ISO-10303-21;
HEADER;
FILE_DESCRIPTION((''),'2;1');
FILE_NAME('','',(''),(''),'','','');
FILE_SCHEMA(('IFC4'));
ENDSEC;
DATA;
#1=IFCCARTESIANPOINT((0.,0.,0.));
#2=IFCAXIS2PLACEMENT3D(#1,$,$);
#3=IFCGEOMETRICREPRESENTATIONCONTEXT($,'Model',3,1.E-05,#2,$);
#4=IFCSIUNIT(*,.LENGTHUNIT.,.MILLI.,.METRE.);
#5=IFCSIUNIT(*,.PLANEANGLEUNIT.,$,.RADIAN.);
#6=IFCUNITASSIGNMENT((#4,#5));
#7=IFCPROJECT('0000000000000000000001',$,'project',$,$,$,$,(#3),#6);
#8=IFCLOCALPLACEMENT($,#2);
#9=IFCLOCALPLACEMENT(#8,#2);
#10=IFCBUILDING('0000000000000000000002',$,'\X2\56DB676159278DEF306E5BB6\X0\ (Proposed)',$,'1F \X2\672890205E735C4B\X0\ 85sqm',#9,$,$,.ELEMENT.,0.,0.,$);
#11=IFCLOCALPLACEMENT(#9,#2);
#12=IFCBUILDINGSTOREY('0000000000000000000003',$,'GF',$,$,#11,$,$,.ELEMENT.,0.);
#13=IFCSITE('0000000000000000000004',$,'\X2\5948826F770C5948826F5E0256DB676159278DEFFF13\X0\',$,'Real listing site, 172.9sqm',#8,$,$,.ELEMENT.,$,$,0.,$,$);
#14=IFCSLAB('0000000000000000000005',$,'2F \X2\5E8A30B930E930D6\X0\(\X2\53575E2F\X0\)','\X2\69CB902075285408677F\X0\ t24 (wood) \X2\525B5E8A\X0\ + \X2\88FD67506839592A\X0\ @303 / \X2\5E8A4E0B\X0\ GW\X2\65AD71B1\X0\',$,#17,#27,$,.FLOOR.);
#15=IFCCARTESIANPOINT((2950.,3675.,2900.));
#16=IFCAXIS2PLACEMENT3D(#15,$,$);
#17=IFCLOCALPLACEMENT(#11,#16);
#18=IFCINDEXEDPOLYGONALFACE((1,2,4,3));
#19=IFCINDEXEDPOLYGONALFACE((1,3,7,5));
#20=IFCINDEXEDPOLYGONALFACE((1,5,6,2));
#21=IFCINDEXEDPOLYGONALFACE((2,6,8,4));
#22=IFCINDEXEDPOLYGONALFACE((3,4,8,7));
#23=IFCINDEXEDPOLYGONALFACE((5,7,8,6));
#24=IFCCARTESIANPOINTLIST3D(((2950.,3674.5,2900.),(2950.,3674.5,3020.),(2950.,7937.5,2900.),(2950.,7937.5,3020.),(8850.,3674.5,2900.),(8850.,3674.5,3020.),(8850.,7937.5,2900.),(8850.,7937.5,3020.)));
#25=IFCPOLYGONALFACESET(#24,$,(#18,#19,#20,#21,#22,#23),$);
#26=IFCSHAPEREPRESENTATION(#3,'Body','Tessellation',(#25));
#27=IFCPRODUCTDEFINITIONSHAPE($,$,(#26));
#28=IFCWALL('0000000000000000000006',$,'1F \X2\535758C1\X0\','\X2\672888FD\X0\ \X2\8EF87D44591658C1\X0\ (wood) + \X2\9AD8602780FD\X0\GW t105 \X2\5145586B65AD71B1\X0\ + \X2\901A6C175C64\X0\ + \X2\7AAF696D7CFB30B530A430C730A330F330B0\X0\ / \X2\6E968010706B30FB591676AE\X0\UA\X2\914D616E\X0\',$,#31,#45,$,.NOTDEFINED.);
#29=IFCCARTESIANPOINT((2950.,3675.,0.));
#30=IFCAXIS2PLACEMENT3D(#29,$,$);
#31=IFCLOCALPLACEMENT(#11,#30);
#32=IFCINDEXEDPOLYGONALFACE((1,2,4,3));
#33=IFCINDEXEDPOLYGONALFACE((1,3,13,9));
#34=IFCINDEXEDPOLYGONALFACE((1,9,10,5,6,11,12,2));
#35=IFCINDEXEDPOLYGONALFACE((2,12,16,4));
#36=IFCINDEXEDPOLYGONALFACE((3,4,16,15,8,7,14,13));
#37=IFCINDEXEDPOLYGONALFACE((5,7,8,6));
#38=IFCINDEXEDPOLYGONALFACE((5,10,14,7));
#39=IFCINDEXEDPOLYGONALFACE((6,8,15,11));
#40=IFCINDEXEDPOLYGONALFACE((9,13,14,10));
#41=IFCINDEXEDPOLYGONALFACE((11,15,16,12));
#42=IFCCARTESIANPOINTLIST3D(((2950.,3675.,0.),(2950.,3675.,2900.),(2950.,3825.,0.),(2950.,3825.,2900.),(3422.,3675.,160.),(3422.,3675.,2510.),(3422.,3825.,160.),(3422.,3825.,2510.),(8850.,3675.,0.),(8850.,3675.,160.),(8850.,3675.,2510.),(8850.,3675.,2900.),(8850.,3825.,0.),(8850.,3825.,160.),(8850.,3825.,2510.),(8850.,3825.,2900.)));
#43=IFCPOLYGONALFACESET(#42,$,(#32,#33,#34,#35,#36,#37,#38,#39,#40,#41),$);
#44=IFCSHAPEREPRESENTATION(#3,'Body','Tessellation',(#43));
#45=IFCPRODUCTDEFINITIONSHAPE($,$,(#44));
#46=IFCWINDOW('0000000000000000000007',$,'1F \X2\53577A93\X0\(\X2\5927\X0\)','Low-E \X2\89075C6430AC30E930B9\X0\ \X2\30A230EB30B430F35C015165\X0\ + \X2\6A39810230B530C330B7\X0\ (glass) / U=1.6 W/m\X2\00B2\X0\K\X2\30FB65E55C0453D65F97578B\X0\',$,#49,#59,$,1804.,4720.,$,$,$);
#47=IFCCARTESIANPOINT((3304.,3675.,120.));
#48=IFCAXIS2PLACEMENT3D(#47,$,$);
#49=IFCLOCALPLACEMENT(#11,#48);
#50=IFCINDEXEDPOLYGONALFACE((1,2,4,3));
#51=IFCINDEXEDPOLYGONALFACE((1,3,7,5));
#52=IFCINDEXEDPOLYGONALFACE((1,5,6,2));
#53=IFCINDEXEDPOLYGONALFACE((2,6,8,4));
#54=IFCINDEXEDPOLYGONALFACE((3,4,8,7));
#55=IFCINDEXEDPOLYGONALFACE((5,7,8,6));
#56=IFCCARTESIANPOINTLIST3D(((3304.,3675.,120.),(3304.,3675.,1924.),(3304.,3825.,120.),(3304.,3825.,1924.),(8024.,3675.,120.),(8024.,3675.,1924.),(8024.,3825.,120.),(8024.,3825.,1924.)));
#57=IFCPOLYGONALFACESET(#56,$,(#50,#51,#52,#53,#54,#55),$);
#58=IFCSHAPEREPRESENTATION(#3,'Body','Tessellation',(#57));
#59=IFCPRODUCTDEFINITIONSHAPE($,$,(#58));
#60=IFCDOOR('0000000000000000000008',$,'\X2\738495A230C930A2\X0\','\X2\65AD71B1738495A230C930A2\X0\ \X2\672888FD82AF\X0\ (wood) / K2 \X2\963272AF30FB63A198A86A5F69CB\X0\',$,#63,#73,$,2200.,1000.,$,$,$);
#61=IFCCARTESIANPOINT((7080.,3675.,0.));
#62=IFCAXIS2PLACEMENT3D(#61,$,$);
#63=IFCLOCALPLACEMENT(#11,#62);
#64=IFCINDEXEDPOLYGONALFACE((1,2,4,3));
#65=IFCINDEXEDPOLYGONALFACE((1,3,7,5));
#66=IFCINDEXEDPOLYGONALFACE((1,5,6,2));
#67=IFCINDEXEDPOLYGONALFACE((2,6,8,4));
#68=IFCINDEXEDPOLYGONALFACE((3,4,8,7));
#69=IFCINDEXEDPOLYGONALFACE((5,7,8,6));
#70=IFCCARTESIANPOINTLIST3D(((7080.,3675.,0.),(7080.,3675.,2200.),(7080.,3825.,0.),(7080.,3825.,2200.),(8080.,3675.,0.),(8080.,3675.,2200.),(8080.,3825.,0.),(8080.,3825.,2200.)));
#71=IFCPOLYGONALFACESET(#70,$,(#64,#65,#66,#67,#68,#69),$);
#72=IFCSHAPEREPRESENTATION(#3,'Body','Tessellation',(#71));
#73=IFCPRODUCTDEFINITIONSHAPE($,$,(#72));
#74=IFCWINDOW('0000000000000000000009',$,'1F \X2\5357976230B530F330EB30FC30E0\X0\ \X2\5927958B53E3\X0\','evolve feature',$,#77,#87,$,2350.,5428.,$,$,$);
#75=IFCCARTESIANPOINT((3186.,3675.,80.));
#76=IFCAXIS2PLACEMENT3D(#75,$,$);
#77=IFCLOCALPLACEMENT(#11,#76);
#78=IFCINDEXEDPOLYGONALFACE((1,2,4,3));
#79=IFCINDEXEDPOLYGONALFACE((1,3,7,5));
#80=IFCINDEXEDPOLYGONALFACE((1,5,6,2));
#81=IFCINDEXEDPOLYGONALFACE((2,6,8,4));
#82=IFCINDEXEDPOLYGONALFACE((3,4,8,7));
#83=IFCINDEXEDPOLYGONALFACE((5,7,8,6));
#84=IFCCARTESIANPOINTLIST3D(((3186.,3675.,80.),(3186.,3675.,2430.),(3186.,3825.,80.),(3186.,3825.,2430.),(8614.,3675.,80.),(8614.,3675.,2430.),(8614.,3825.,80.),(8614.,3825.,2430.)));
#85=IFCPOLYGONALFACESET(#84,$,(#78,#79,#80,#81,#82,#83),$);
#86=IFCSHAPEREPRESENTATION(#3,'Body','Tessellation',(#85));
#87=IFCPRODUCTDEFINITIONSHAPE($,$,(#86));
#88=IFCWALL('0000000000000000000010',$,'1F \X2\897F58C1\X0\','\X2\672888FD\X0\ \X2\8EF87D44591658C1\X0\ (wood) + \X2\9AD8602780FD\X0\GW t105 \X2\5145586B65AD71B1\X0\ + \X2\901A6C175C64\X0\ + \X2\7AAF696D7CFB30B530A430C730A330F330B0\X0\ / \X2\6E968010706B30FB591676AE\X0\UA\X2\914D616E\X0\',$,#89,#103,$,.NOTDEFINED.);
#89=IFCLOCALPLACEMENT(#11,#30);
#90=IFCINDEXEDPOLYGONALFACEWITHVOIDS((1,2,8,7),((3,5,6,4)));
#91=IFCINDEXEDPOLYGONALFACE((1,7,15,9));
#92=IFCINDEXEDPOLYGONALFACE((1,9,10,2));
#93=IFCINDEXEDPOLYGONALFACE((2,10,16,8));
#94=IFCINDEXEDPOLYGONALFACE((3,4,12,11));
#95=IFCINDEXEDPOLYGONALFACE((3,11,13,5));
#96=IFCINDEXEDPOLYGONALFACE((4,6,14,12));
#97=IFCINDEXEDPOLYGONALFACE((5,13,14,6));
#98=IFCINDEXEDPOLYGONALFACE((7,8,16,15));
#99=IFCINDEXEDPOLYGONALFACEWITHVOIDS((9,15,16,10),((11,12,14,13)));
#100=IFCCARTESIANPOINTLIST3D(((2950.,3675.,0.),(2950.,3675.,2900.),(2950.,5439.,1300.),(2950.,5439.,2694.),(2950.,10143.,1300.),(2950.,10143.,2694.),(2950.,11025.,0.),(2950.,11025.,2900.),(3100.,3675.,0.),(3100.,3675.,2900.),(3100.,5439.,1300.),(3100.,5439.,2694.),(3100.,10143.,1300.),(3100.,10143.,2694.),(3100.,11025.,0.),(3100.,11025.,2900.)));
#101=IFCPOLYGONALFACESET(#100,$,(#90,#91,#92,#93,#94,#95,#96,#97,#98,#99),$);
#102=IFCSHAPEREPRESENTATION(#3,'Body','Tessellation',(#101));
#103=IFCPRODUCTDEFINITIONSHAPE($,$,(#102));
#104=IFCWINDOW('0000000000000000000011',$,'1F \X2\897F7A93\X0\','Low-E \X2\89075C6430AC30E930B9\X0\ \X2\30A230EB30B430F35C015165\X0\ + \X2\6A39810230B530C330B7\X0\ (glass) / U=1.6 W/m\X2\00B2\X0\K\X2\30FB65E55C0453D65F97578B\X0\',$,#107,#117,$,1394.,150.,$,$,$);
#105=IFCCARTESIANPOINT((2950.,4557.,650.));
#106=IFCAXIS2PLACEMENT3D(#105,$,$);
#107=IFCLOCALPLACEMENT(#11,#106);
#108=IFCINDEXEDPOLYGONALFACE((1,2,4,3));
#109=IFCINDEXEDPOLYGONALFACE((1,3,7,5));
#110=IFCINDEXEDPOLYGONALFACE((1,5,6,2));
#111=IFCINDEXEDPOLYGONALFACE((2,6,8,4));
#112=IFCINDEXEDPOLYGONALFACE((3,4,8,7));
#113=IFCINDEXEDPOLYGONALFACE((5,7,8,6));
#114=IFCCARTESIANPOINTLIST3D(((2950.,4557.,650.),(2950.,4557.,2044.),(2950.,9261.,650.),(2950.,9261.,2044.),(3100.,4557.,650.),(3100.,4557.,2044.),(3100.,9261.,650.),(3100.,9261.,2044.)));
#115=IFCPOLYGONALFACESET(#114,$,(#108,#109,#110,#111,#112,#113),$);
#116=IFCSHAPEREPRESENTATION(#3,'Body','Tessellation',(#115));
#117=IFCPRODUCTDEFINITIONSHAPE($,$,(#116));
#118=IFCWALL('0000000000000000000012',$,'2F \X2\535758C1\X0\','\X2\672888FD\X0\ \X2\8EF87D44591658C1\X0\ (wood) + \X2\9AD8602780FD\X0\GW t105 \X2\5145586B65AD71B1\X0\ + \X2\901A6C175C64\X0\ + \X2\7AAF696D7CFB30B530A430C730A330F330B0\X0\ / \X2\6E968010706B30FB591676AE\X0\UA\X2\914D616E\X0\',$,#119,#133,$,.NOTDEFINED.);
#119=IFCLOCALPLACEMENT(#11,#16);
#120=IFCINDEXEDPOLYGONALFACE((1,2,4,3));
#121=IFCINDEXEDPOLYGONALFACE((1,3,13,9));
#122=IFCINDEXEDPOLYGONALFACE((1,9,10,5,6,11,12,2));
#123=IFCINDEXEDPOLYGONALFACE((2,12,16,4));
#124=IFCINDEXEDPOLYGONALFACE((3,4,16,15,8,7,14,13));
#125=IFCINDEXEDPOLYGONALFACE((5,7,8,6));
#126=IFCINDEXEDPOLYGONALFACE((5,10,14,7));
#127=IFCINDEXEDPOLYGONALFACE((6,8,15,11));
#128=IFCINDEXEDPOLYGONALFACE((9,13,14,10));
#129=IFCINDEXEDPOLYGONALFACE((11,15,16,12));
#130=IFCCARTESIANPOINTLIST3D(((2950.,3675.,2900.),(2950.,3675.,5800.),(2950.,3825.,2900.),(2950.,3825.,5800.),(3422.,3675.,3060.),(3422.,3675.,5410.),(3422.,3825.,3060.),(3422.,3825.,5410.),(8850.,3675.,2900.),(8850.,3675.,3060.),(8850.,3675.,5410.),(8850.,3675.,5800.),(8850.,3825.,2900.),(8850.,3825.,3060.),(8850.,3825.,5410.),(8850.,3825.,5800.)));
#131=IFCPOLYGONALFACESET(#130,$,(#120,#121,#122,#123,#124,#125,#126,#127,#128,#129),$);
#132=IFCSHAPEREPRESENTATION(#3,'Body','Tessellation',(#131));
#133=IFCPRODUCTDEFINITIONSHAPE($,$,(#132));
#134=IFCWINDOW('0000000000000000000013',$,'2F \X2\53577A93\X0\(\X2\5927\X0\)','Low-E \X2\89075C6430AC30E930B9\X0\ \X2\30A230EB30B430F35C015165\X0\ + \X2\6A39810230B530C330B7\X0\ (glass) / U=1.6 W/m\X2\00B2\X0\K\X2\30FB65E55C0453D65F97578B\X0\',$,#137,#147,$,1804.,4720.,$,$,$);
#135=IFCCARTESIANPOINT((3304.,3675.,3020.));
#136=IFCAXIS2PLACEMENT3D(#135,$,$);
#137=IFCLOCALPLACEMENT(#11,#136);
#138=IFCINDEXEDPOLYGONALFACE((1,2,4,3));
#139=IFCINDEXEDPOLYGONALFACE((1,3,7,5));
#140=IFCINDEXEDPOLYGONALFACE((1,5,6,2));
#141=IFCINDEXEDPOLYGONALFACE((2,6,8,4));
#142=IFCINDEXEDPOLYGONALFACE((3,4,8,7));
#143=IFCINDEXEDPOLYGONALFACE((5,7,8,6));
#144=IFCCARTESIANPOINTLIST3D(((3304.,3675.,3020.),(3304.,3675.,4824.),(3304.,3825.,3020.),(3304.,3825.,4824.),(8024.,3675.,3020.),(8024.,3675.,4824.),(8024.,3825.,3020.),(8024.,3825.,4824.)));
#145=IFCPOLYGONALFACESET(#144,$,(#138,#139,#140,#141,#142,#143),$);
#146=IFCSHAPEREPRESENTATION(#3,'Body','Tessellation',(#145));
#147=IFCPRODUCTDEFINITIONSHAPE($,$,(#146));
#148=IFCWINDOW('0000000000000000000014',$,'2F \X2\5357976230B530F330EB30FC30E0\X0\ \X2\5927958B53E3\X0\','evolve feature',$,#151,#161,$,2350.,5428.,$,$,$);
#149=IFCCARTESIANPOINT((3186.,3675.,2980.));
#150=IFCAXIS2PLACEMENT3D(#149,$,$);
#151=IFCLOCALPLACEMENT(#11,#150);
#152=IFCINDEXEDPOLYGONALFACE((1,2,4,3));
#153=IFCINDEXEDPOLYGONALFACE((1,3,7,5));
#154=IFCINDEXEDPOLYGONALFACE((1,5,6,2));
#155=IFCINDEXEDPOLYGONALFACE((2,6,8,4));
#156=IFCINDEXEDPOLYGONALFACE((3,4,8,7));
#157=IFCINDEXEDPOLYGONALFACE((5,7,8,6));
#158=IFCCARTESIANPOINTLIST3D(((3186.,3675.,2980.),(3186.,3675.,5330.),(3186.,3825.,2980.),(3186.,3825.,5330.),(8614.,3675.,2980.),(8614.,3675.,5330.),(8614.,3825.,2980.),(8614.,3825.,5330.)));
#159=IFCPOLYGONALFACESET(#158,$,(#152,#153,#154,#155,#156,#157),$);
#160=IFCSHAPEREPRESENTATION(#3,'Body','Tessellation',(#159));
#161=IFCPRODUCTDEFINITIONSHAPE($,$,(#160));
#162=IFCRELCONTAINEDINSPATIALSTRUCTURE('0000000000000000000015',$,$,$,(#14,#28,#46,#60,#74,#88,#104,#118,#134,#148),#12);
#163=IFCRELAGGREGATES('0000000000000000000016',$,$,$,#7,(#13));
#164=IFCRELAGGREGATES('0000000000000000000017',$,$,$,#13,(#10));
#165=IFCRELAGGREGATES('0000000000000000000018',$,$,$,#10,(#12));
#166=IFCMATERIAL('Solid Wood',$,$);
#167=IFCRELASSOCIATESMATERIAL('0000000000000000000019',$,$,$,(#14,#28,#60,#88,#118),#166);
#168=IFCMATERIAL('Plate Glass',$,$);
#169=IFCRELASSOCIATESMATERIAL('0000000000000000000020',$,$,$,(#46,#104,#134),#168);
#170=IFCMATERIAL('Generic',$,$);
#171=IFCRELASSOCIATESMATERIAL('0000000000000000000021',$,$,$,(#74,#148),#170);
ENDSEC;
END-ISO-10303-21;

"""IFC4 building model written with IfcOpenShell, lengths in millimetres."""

from ifc_helpers import new_model, si_unit, frame, frame_2d, origin, place, context, project, spatial, rectangle, extrude, material, element, fill, save


model = new_model("IFC4")

# Units and contexts
model_context = context("Model", 3, precision=1e-05, world=origin())
ifc_project = project(units=[si_unit("LENGTHUNIT", "METRE", prefix="MILLI"), si_unit("PLANEANGLEUNIT", "RADIAN")], contexts=[model_context])

# Site, building, storey
site_placement = place(None, origin())
site = spatial("IfcSite", under=ifc_project, at=site_placement, Name="奈良県奈良市四条大路３", ObjectType="Real listing site, 172.9sqm", CompositionType="ELEMENT", RefElevation=0.0)
building_placement = place(site_placement, origin())
building = spatial("IfcBuilding", under=site, at=building_placement, Name="四条大路の家 (Proposed)", ObjectType="1F 木造平屋 85sqm", CompositionType="ELEMENT", ElevationOfRefHeight=0.0, ElevationOfTerrain=0.0)
storey_placement = place(building_placement, origin())
storey = spatial("IfcBuildingStorey", under=building, at=storey_placement, Name="GF", CompositionType="ELEMENT", Elevation=0.0)

# Slab
ifc_material_1 = material(Name="Solid Wood")
slab_1_placement = place(storey_placement, frame((2950.0, 3675.0, 2900.0)))
element("IfcSlab", 1, at=slab_1_placement, inside=storey, material=ifc_material_1, Name="2F 床スラブ(南帯)", Description="構造用合板 t24 (wood) 剛床 + 製材根太 @303 / 床下 GW断熱", PredefinedType="FLOOR", context=model_context, shape_type="SweptSolid", body=[
    extrude(rectangle(XDim=5900.0, YDim=4263.0, at=frame_2d((2950.0, 2131.0))), frame((2950.0, 3675.0, 2900.0)), (0.0, 0.0, 1.0), 120.0),
])
ifc_material_2 = material(Name="Generic")

# Wall, openings, windows, door
wall_1_placement = place(storey_placement, frame((2950.0, 3675.0, 0.0)))
wall_1 = element("IfcWall", 2, at=wall_1_placement, inside=storey, material=ifc_material_1, Name="1F 南壁", Description="木製 軸組外壁 (wood) + 高性能GW t105 充填断熱 + 通気層 + 窯業系サイディング / 準耐火・外皮UA配慮", PredefinedType="NOTDEFINED", context=model_context, shape_type="SweptSolid", body=[
    extrude(rectangle(XDim=5900.0, YDim=150.0, at=frame_2d((2950.0, 75.0))), frame((2950.0, 3675.0, 0.0)), (0.0, 0.0, 1.0), 2900.0),
])
opening_1_placement = place(storey_placement, frame((3304.0, 3675.0, 120.0)))
opening_1 = element("IfcOpeningElement", 3, at=opening_1_placement, cuts=wall_1, PredefinedType="NOTDEFINED", context=model_context, shape_type="SweptSolid", body=[
    extrude(rectangle(XDim=4720.0, YDim=150.0, at=frame_2d((2360.0, 75.0))), frame((3304.0, 3675.0, 120.0)), (0.0, 0.0, 1.0), 1804.0),
])
opening_2_placement = place(storey_placement, frame((7080.0, 3675.0, 0.0)))
opening_2 = element("IfcOpeningElement", 4, at=opening_2_placement, cuts=wall_1, PredefinedType="NOTDEFINED", context=model_context, shape_type="SweptSolid", body=[
    extrude(rectangle(XDim=1000.0, YDim=150.0, at=frame_2d((500.0, 75.0))), frame((7080.0, 3675.0, 0.0)), (0.0, 0.0, 1.0), 2200.0),
])
opening_3_placement = place(storey_placement, frame((3186.0, 3675.0, 80.0)))
opening_3 = element("IfcOpeningElement", 5, at=opening_3_placement, cuts=wall_1, PredefinedType="NOTDEFINED", context=model_context, shape_type="SweptSolid", body=[
    extrude(rectangle(XDim=5428.0, YDim=150.0, at=frame_2d((2714.0, 75.0))), frame((3186.0, 3675.0, 80.0)), (0.0, 0.0, 1.0), 2350.0),
])
ifc_material_3 = material(Name="Plate Glass")
window_1_placement = place(storey_placement, frame((3304.0, 3675.0, 120.0)))
window_1 = element("IfcWindow", 6, at=window_1_placement, inside=storey, material=ifc_material_3, Name="1F 南窓(大)", Description="Low-E 複層ガラス アルゴン封入 + 樹脂サッシ (glass) / U=1.6 W/m²K・日射取得型", OverallHeight=1804.0, OverallWidth=4720.0, context=model_context, shape_type="SweptSolid", body=[
    extrude(rectangle(XDim=4720.0, YDim=150.0, at=frame_2d((2360.0, 75.0))), frame((3304.0, 3675.0, 120.0)), (0.0, 0.0, 1.0), 1804.0),
])
fill(opening_1, window_1)
door_placement = place(storey_placement, frame((7080.0, 3675.0, 0.0)))
door = element("IfcDoor", 7, at=door_placement, inside=storey, material=ifc_material_1, Name="玄関ドア", Description="断熱玄関ドア 木製芯 (wood) / K2 防犯・採風機構", OverallHeight=2200.0, OverallWidth=1000.0, context=model_context, shape_type="SweptSolid", body=[
    extrude(rectangle(XDim=1000.0, YDim=150.0, at=frame_2d((500.0, 75.0))), frame((7080.0, 3675.0, 0.0)), (0.0, 0.0, 1.0), 2200.0),
])
fill(opening_2, door)
window_2_placement = place(storey_placement, frame((3186.0, 3675.0, 80.0)))
window_2 = element("IfcWindow", 8, at=window_2_placement, inside=storey, material=ifc_material_2, Name="1F 南面サンルーム 大開口", Description="evolve feature", OverallHeight=2350.0, OverallWidth=5428.0, context=model_context, shape_type="SweptSolid", body=[
    extrude(rectangle(XDim=5428.0, YDim=150.0, at=frame_2d((2714.0, 75.0))), frame((3186.0, 3675.0, 80.0)), (0.0, 0.0, 1.0), 2350.0),
])
fill(opening_3, window_2)

# Wall, opening, window
wall_2_placement = place(storey_placement, frame((2950.0, 3675.0, 0.0)))
wall_2 = element("IfcWall", 9, at=wall_2_placement, inside=storey, material=ifc_material_1, Name="1F 西壁", Description="木製 軸組外壁 (wood) + 高性能GW t105 充填断熱 + 通気層 + 窯業系サイディング / 準耐火・外皮UA配慮", PredefinedType="NOTDEFINED", context=model_context, shape_type="SweptSolid", body=[
    extrude(rectangle(XDim=150.0, YDim=7350.0, at=frame_2d((75.0, 3675.0))), frame((2950.0, 3675.0, 0.0)), (0.0, 0.0, 1.0), 2900.0),
])
opening_4_placement = place(storey_placement, frame((2950.0, 4557.0, 650.0)))
opening_4 = element("IfcOpeningElement", 10, at=opening_4_placement, cuts=wall_2, PredefinedType="NOTDEFINED", context=model_context, shape_type="SweptSolid", body=[
    extrude(rectangle(XDim=150.0, YDim=4704.0, at=frame_2d((75.0, 2352.0))), frame((2950.0, 4557.0, 650.0)), (0.0, 0.0, 1.0), 1394.0),
])
window_3_placement = place(storey_placement, frame((2950.0, 4557.0, 650.0)))
window_3 = element("IfcWindow", 11, at=window_3_placement, inside=storey, material=ifc_material_3, Name="1F 西窓", Description="Low-E 複層ガラス アルゴン封入 + 樹脂サッシ (glass) / U=1.6 W/m²K・日射取得型", OverallHeight=1394.0, OverallWidth=150.0, context=model_context, shape_type="SweptSolid", body=[
    extrude(rectangle(XDim=150.0, YDim=4704.0, at=frame_2d((75.0, 2352.0))), frame((2950.0, 4557.0, 650.0)), (0.0, 0.0, 1.0), 1394.0),
])
fill(opening_4, window_3)

# Wall, openings, windows
wall_3_placement = place(storey_placement, frame((2950.0, 3675.0, 2900.0)))
wall_3 = element("IfcWall", 12, at=wall_3_placement, inside=storey, material=ifc_material_1, Name="2F 南壁", Description="木製 軸組外壁 (wood) + 高性能GW t105 充填断熱 + 通気層 + 窯業系サイディング / 準耐火・外皮UA配慮", PredefinedType="NOTDEFINED", context=model_context, shape_type="SweptSolid", body=[
    extrude(rectangle(XDim=5900.0, YDim=150.0, at=frame_2d((2950.0, 75.0))), frame((2950.0, 3675.0, 2900.0)), (0.0, 0.0, 1.0), 2900.0),
])
opening_5_placement = place(storey_placement, frame((3304.0, 3675.0, 3020.0)))
opening_5 = element("IfcOpeningElement", 13, at=opening_5_placement, cuts=wall_3, PredefinedType="NOTDEFINED", context=model_context, shape_type="SweptSolid", body=[
    extrude(rectangle(XDim=4720.0, YDim=150.0, at=frame_2d((2360.0, 75.0))), frame((3304.0, 3675.0, 3020.0)), (0.0, 0.0, 1.0), 1804.0),
])
opening_6_placement = place(storey_placement, frame((3186.0, 3675.0, 2980.0)))
opening_6 = element("IfcOpeningElement", 14, at=opening_6_placement, cuts=wall_3, PredefinedType="NOTDEFINED", context=model_context, shape_type="SweptSolid", body=[
    extrude(rectangle(XDim=5428.0, YDim=150.0, at=frame_2d((2714.0, 75.0))), frame((3186.0, 3675.0, 2980.0)), (0.0, 0.0, 1.0), 2350.0),
])
window_4_placement = place(storey_placement, frame((3304.0, 3675.0, 3020.0)))
window_4 = element("IfcWindow", 15, at=window_4_placement, inside=storey, material=ifc_material_3, Name="2F 南窓(大)", Description="Low-E 複層ガラス アルゴン封入 + 樹脂サッシ (glass) / U=1.6 W/m²K・日射取得型", OverallHeight=1804.0, OverallWidth=4720.0, context=model_context, shape_type="SweptSolid", body=[
    extrude(rectangle(XDim=4720.0, YDim=150.0, at=frame_2d((2360.0, 75.0))), frame((3304.0, 3675.0, 3020.0)), (0.0, 0.0, 1.0), 1804.0),
])
fill(opening_5, window_4)
window_5_placement = place(storey_placement, frame((3186.0, 3675.0, 2980.0)))
window_5 = element("IfcWindow", 16, at=window_5_placement, inside=storey, material=ifc_material_2, Name="2F 南面サンルーム 大開口", Description="evolve feature", OverallHeight=2350.0, OverallWidth=5428.0, context=model_context, shape_type="SweptSolid", body=[
    extrude(rectangle(XDim=5428.0, YDim=150.0, at=frame_2d((2714.0, 75.0))), frame((3186.0, 3675.0, 2980.0)), (0.0, 0.0, 1.0), 2350.0),
])
fill(opening_6, window_5)

save(model, "model.ifc")
